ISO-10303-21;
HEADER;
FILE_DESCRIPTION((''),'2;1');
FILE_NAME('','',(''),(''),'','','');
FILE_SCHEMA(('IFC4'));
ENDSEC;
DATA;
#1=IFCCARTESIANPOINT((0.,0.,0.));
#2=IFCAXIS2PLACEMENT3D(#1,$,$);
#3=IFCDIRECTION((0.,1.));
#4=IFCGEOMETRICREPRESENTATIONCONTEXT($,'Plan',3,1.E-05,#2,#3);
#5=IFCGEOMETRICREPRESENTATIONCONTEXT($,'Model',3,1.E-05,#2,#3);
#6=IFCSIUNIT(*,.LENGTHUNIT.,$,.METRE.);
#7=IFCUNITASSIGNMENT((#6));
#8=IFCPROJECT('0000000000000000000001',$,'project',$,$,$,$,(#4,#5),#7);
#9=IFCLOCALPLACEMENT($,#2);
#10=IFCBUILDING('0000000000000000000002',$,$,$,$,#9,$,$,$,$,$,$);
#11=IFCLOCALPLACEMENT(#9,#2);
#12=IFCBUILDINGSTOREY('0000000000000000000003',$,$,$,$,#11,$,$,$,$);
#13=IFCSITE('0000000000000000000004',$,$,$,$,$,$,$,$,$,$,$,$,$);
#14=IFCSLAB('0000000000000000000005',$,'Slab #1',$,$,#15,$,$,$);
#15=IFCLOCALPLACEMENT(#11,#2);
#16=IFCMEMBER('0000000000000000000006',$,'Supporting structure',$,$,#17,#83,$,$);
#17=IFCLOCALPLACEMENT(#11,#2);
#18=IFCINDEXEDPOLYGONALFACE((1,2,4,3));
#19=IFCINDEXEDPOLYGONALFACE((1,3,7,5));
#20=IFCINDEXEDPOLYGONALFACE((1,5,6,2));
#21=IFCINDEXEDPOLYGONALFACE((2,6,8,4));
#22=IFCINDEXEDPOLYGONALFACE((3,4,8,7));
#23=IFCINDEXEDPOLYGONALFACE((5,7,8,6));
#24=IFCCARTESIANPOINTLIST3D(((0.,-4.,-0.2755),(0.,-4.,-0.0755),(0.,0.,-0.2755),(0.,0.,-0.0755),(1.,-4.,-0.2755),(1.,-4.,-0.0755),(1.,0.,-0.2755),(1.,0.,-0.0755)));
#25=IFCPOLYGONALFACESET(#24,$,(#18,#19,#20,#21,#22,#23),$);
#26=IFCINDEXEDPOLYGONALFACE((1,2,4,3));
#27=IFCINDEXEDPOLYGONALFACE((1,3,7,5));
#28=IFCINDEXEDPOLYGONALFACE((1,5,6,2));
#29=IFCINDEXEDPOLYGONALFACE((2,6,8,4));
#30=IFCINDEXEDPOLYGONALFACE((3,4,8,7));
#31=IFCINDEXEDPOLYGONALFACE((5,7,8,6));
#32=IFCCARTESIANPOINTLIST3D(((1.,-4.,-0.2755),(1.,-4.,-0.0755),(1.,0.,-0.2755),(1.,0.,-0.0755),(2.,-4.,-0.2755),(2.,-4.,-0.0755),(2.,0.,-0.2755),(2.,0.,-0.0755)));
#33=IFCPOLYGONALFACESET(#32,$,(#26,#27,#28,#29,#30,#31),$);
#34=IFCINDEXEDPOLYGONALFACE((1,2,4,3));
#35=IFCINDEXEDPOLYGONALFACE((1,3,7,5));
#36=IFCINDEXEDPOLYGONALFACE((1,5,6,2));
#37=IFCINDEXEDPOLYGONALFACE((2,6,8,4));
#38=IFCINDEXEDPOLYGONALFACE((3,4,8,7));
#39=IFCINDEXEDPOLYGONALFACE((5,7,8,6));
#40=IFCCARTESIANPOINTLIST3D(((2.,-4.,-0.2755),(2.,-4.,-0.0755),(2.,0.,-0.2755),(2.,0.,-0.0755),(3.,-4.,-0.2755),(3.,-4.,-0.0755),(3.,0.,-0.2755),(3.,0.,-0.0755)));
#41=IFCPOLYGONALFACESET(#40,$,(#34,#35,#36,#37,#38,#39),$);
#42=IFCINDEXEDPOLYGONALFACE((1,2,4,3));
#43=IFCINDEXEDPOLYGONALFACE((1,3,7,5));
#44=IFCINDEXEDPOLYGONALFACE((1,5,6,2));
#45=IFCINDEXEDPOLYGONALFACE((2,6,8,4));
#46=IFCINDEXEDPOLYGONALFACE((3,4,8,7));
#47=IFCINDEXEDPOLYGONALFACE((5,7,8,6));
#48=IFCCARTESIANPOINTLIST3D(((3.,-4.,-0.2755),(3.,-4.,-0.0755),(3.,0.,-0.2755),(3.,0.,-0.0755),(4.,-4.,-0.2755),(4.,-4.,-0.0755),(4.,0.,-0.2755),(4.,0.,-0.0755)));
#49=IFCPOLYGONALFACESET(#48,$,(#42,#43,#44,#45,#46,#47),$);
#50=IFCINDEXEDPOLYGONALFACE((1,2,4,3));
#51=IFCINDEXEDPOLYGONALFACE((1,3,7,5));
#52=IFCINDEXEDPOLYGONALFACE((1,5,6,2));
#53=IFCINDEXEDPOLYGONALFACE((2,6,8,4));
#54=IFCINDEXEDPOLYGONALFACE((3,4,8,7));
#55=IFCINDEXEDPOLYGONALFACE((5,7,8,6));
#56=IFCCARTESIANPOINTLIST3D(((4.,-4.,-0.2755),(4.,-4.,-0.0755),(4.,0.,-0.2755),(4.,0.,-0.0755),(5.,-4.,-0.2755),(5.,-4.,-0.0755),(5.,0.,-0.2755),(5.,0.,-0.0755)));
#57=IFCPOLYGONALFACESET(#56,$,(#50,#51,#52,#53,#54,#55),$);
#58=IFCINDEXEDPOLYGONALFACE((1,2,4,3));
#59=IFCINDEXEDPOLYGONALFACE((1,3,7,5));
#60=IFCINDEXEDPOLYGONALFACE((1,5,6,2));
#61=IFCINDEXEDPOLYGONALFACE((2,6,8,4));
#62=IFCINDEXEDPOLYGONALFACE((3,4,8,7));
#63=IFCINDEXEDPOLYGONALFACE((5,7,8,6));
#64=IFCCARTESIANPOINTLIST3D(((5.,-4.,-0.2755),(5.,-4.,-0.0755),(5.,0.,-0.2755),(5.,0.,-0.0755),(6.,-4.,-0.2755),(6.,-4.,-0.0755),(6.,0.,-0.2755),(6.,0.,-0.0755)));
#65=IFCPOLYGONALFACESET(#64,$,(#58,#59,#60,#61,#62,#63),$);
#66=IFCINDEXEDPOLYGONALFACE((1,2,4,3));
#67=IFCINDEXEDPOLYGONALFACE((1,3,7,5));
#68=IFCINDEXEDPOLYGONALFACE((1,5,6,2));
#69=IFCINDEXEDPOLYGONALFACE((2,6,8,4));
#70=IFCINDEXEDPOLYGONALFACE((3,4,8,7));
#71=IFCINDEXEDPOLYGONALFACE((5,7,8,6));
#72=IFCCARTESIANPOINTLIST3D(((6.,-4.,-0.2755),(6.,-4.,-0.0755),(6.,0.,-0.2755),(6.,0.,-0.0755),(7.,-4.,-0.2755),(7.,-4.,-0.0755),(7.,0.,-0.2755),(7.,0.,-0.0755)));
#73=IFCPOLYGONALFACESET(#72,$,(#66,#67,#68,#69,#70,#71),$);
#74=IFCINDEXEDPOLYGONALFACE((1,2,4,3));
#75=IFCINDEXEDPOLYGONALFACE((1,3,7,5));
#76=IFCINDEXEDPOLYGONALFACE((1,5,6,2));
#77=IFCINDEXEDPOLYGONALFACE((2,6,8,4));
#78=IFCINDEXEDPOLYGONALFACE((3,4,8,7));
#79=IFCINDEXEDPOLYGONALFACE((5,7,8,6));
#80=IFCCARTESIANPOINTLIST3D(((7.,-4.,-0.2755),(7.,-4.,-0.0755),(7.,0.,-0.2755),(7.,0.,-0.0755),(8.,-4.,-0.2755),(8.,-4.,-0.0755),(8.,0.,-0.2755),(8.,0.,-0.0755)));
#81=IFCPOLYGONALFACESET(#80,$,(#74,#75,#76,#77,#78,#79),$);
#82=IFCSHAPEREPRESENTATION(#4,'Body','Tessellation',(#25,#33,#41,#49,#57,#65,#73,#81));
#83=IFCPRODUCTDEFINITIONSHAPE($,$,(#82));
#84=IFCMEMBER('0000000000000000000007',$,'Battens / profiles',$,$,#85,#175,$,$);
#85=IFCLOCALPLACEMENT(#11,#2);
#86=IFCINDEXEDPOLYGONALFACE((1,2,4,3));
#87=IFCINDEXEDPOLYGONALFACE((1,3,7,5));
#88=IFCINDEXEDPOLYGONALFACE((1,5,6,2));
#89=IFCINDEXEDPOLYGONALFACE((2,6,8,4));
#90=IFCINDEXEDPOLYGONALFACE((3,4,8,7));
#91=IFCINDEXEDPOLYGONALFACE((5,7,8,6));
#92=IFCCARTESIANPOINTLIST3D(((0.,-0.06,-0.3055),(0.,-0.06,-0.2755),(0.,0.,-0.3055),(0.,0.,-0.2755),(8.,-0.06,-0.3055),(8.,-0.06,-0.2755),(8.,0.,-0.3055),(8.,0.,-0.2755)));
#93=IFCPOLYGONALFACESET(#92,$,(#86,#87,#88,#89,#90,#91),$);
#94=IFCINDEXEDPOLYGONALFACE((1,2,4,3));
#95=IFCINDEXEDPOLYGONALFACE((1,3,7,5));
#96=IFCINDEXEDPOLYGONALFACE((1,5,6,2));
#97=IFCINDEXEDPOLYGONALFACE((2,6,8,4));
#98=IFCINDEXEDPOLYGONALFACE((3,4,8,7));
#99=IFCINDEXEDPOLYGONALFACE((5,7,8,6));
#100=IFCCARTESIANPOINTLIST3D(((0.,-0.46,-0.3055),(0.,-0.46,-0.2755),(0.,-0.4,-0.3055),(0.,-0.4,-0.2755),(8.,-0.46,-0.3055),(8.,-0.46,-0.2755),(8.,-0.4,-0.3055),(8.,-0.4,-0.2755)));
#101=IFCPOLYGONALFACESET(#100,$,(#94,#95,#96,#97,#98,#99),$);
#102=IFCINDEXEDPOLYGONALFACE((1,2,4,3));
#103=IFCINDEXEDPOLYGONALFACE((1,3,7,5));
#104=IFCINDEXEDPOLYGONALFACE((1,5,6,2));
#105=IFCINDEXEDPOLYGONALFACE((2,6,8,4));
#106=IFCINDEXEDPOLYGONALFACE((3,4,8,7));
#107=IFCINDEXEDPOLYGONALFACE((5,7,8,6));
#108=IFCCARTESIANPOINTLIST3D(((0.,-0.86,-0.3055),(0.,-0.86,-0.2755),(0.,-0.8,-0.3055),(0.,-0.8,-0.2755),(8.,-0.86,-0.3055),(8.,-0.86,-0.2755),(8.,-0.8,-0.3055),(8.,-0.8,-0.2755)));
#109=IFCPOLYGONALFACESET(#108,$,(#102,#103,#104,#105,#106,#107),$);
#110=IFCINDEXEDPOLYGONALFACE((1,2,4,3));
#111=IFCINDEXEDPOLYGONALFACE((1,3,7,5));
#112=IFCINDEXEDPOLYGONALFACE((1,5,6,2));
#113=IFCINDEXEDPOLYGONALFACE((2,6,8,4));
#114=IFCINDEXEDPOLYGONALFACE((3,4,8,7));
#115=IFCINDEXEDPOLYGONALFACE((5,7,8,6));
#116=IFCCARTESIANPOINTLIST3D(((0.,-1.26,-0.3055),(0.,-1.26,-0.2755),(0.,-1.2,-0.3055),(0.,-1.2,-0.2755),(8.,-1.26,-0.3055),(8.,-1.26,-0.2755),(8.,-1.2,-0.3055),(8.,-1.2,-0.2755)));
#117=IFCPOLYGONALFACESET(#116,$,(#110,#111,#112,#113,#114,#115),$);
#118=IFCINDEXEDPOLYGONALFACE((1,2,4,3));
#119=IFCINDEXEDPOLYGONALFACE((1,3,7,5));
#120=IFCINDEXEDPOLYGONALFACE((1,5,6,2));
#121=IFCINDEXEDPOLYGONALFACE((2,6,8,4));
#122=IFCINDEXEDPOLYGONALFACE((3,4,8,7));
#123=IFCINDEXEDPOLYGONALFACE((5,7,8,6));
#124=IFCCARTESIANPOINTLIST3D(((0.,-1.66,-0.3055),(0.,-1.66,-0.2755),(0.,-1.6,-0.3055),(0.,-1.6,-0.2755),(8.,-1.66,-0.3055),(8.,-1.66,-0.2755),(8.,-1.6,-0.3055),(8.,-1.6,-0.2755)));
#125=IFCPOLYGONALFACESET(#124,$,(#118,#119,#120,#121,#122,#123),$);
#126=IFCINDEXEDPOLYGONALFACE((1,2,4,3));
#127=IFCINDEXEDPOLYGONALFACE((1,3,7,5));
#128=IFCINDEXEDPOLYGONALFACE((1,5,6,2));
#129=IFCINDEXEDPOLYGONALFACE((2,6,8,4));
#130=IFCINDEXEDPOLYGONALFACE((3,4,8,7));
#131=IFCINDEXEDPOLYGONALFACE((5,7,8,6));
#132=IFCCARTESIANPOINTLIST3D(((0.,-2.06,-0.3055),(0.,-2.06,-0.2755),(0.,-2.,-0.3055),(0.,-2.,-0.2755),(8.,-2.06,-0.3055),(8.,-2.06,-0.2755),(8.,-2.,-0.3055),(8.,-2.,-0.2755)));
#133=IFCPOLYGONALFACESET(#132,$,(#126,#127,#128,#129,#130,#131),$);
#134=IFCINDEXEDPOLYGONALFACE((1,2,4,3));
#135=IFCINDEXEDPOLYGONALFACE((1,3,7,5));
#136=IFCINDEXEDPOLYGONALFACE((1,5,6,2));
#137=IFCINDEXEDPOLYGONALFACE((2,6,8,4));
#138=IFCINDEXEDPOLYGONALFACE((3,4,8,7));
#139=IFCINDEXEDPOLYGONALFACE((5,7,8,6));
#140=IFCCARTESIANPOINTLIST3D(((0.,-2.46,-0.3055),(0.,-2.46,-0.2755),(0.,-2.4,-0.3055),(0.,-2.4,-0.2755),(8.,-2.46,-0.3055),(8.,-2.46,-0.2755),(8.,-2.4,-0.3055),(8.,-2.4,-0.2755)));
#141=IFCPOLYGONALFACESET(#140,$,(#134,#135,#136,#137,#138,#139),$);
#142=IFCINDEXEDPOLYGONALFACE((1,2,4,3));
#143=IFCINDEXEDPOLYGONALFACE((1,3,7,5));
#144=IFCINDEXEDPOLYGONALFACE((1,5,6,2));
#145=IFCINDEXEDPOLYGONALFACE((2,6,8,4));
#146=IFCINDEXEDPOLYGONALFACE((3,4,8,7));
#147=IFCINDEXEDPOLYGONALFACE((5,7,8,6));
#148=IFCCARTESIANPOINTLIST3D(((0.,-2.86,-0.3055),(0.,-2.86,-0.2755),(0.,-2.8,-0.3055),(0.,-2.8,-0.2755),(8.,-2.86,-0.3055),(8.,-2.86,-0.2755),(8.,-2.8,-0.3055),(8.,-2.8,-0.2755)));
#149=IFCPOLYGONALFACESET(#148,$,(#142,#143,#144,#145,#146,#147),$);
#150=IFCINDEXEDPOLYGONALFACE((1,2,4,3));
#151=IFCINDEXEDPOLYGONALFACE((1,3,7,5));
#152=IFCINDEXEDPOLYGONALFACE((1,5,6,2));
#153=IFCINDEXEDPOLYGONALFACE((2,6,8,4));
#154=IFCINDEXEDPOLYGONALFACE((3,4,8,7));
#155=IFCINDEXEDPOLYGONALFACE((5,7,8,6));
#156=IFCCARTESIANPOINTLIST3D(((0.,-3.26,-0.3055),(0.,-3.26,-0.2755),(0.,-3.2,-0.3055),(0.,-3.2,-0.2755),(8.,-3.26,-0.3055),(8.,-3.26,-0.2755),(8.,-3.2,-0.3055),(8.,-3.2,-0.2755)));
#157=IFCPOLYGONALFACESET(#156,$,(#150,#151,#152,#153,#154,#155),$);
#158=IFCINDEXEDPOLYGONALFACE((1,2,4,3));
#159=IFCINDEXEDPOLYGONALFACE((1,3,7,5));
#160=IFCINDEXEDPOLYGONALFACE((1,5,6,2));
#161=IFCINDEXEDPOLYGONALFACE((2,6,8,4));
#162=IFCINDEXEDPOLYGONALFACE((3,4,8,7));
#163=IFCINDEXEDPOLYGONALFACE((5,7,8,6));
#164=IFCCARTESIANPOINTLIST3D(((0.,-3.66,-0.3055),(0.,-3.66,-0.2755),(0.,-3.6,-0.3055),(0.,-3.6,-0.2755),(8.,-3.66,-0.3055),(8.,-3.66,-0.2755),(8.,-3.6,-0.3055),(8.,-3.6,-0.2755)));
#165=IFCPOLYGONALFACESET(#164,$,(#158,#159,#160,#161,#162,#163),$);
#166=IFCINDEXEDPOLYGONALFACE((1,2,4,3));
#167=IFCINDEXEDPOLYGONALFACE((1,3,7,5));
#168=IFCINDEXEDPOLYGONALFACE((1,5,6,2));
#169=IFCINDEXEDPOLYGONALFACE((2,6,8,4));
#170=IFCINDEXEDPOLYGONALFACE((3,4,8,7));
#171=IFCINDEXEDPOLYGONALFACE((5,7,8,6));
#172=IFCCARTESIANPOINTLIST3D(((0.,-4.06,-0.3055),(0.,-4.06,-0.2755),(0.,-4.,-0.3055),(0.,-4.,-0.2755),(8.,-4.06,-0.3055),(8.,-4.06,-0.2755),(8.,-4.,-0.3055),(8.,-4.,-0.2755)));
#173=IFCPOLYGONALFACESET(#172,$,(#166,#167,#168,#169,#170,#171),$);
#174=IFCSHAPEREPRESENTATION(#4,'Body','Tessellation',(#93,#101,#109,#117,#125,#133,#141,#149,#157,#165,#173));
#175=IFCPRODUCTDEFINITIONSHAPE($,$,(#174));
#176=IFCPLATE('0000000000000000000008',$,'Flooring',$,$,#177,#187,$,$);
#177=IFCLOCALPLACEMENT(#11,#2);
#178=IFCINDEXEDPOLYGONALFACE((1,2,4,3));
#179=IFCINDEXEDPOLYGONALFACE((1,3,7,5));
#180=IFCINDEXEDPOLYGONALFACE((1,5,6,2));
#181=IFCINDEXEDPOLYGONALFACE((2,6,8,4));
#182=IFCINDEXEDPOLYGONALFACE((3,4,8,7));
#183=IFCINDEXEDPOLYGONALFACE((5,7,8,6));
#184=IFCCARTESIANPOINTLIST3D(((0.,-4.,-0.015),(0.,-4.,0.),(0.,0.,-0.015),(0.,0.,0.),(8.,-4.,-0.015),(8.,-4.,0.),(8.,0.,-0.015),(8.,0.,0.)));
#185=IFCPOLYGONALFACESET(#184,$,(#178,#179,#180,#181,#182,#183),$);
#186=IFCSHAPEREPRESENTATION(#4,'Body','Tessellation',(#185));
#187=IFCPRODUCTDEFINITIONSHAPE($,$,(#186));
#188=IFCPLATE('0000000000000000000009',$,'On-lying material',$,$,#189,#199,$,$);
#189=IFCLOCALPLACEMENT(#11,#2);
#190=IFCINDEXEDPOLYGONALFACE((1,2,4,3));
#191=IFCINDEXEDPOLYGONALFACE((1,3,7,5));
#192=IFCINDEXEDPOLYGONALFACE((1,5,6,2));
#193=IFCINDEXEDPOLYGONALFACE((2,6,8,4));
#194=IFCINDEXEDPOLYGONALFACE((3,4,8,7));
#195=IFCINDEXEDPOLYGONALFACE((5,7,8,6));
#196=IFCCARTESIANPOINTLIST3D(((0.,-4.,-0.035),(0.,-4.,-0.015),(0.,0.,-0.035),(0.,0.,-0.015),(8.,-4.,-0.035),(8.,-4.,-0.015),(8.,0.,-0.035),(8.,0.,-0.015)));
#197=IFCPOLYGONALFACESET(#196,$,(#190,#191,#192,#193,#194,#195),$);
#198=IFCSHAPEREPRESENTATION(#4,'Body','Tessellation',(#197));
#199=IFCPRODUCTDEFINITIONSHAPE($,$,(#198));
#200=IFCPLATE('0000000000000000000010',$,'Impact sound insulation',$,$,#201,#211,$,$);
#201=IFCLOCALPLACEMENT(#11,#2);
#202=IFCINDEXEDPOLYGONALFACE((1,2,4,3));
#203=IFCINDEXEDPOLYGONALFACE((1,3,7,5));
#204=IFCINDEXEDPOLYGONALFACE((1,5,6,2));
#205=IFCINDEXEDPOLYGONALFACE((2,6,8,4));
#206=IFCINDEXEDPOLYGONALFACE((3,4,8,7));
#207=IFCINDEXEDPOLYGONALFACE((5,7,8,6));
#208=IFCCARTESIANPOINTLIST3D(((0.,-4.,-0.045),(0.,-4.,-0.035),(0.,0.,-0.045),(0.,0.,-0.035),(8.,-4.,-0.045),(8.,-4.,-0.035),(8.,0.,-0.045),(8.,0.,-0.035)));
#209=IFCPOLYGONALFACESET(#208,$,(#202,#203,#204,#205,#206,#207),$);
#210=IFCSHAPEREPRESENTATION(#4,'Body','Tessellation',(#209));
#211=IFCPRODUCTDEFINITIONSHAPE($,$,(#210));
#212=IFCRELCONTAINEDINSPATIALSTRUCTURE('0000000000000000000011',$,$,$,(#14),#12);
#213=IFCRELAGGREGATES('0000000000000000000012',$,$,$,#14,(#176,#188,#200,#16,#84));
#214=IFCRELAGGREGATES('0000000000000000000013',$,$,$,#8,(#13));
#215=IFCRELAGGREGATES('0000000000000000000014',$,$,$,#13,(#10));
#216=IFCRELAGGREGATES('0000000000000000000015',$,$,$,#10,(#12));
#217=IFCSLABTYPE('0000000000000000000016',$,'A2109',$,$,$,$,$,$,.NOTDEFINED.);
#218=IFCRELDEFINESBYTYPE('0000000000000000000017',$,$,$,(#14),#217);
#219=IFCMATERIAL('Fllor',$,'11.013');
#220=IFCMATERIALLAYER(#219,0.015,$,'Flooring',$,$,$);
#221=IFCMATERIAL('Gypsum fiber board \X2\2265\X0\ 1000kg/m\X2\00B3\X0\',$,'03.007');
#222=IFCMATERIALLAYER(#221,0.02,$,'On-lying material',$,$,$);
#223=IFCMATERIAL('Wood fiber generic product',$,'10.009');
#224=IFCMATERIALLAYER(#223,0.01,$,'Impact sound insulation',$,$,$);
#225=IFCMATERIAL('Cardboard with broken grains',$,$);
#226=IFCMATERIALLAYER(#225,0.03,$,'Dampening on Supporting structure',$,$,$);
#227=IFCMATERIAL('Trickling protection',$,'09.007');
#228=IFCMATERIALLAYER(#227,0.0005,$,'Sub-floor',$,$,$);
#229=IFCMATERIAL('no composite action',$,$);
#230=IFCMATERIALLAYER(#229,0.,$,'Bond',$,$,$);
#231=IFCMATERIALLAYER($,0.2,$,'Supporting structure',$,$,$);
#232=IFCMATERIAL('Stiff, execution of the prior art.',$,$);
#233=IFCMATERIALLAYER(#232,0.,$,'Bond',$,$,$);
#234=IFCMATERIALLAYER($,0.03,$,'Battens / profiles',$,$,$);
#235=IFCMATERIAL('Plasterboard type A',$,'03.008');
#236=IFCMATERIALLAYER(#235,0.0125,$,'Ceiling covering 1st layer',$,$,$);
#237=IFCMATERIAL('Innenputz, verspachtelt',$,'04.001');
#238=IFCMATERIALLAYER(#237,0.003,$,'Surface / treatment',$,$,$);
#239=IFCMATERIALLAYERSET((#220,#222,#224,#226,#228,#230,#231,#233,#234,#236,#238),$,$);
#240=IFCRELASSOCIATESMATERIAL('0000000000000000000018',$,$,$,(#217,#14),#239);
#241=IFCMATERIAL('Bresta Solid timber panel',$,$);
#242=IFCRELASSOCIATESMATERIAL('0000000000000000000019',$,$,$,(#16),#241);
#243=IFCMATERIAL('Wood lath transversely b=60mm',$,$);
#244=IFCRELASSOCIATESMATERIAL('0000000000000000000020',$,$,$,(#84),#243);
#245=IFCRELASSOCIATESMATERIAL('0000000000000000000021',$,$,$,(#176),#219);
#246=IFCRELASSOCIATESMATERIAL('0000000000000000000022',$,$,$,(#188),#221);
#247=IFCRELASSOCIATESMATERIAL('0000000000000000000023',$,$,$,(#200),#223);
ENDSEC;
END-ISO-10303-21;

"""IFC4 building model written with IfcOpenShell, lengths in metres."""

from ifc_helpers import new_model, si_unit, direction, frame, frame_2d, origin, origin_with_axes, place, context, project, spatial, rectangle, extrude, material, layer, layer_set, type_object, element, aggregate, save


model = new_model("IFC4")

# Units and contexts
plan_context = context("Plan", 3, precision=1e-05, world=origin(), true_north=direction((0.0, 1.0)))
model_context = context("Model", 3, precision=1e-05, world=origin(), true_north=direction((0.0, 1.0)))
ifc_project = project(units=[si_unit("LENGTHUNIT", "METRE")], contexts=[plan_context, model_context])

# Site, building, storey
site = spatial("IfcSite", under=ifc_project)
building_placement = place(None, origin())
building = spatial("IfcBuilding", under=site, at=building_placement)
storey_placement = place(building_placement, origin())
storey = spatial("IfcBuildingStorey", under=building, at=storey_placement)

# Slab, members, plates
ifc_material_1 = material(Name="Fllor", Category="11.013")
ifc_layer_1 = layer(ifc_material_1, 0.015, Name="Flooring")
ifc_material_2 = material(Name="Gypsum fiber board ≥ 1000kg/m³", Category="03.007")
ifc_layer_2 = layer(ifc_material_2, 0.02, Name="On-lying material")
ifc_material_3 = material(Name="Wood fiber generic product", Category="10.009")
ifc_layer_3 = layer(ifc_material_3, 0.01, Name="Impact sound insulation")
ifc_material_4 = material(Name="Cardboard with broken grains")
ifc_layer_4 = layer(ifc_material_4, 0.03, Name="Dampening on Supporting structure")
ifc_material_5 = material(Name="Trickling protection", Category="09.007")
ifc_layer_5 = layer(ifc_material_5, 0.0005, Name="Sub-floor")
ifc_material_6 = material(Name="no composite action")
ifc_layer_6 = layer(ifc_material_6, 0.0, Name="Bond")
ifc_layer_7 = layer(None, 0.2, Name="Supporting structure")
ifc_material_7 = material(Name="Stiff, execution of the prior art.")
ifc_layer_8 = layer(ifc_material_7, 0.0, Name="Bond")
ifc_layer_9 = layer(None, 0.03, Name="Battens / profiles")
ifc_material_8 = material(Name="Plasterboard type A", Category="03.008")
ifc_layer_10 = layer(ifc_material_8, 0.0125, Name="Ceiling covering 1st layer")
ifc_material_9 = material(Name="Innenputz, verspachtelt", Category="04.001")
ifc_layer_11 = layer(ifc_material_9, 0.003, Name="Surface / treatment")
ifc_layer_set = layer_set([ifc_layer_1, ifc_layer_2, ifc_layer_3, ifc_layer_4, ifc_layer_5, ifc_layer_6, ifc_layer_7, ifc_layer_8, ifc_layer_9, ifc_layer_10, ifc_layer_11])
slab_type = type_object("IfcSlabType", Name="A2109", PredefinedType="NOTDEFINED", material=ifc_layer_set)
slab_placement = place(None, frame((0.0, 0.0, 0.0), z_axis=(0.0, 0.0, -1.0), x_axis=(1.0, 0.0, 0.0)))
slab = element("IfcSlab", 1, at=slab_placement, inside=storey, type_object=slab_type, material=ifc_layer_set, Name="Slab #1")
ifc_material_10 = material(Name="Bresta Solid timber panel")
member_1_placement = place(slab_placement, origin())
member_1 = element("IfcMember", 2, at=member_1_placement, material=ifc_material_10, Name="Supporting structure", context=plan_context, shape_type="SweptSolid", body=[
    extrude(rectangle(XDim=1.0, YDim=0.2, at=frame_2d((0.5, 0.1), x_axis=(1.0, 0.0))), frame((0.0, 4.0, 0.0755), z_axis=(0.0, -1.0, 0.0), x_axis=(1.0, 0.0, 0.0)), (0.0, 0.0, 1.0), 4.0),
    extrude(rectangle(XDim=1.0, YDim=0.2, at=frame_2d((0.5, 0.1), x_axis=(1.0, 0.0))), frame((1.0, 4.0, 0.0755), z_axis=(0.0, -1.0, 0.0), x_axis=(1.0, 0.0, 0.0)), (0.0, 0.0, 1.0), 4.0),
    extrude(rectangle(XDim=1.0, YDim=0.2, at=frame_2d((0.5, 0.1), x_axis=(1.0, 0.0))), frame((2.0, 4.0, 0.0755), z_axis=(0.0, -1.0, 0.0), x_axis=(1.0, 0.0, 0.0)), (0.0, 0.0, 1.0), 4.0),
    extrude(rectangle(XDim=1.0, YDim=0.2, at=frame_2d((0.5, 0.1), x_axis=(1.0, 0.0))), frame((3.0, 4.0, 0.0755), z_axis=(0.0, -1.0, 0.0), x_axis=(1.0, 0.0, 0.0)), (0.0, 0.0, 1.0), 4.0),
    extrude(rectangle(XDim=1.0, YDim=0.2, at=frame_2d((0.5, 0.1), x_axis=(1.0, 0.0))), frame((4.0, 4.0, 0.0755), z_axis=(0.0, -1.0, 0.0), x_axis=(1.0, 0.0, 0.0)), (0.0, 0.0, 1.0), 4.0),
    extrude(rectangle(XDim=1.0, YDim=0.2, at=frame_2d((0.5, 0.1), x_axis=(1.0, 0.0))), frame((5.0, 4.0, 0.0755), z_axis=(0.0, -1.0, 0.0), x_axis=(1.0, 0.0, 0.0)), (0.0, 0.0, 1.0), 4.0),
    extrude(rectangle(XDim=1.0, YDim=0.2, at=frame_2d((0.5, 0.1), x_axis=(1.0, 0.0))), frame((6.0, 4.0, 0.0755), z_axis=(0.0, -1.0, 0.0), x_axis=(1.0, 0.0, 0.0)), (0.0, 0.0, 1.0), 4.0),
    extrude(rectangle(XDim=1.0, YDim=0.2, at=frame_2d((0.5, 0.1), x_axis=(1.0, 0.0))), frame((7.0, 4.0, 0.0755), z_axis=(0.0, -1.0, 0.0), x_axis=(1.0, 0.0, 0.0)), (0.0, 0.0, 1.0), 4.0),
])
ifc_material_11 = material(Name="Wood lath transversely b=60mm")
member_2_placement = place(slab_placement, origin())
member_2 = element("IfcMember", 3, at=member_2_placement, material=ifc_material_11, Name="Battens / profiles", context=plan_context, shape_type="SweptSolid", body=[
    extrude(rectangle(XDim=0.06, YDim=0.03, at=frame_2d((0.03, 0.015), x_axis=(1.0, 0.0))), frame((0.0, 0.0, 0.2755), z_axis=(1.0, 0.0, 0.0), x_axis=(0.0, 1.0, 0.0)), (0.0, 0.0, 1.0), 8.0),
    extrude(rectangle(XDim=0.06, YDim=0.03, at=frame_2d((0.03, 0.015), x_axis=(1.0, 0.0))), frame((0.0, 0.4, 0.2755), z_axis=(1.0, 0.0, 0.0), x_axis=(0.0, 1.0, 0.0)), (0.0, 0.0, 1.0), 8.0),
    extrude(rectangle(XDim=0.06, YDim=0.03, at=frame_2d((0.03, 0.015), x_axis=(1.0, 0.0))), frame((0.0, 0.8, 0.2755), z_axis=(1.0, 0.0, 0.0), x_axis=(0.0, 1.0, 0.0)), (0.0, 0.0, 1.0), 8.0),
    extrude(rectangle(XDim=0.06, YDim=0.03, at=frame_2d((0.03, 0.015), x_axis=(1.0, 0.0))), frame((0.0, 1.2, 0.2755), z_axis=(1.0, 0.0, 0.0), x_axis=(0.0, 1.0, 0.0)), (0.0, 0.0, 1.0), 8.0),
    extrude(rectangle(XDim=0.06, YDim=0.03, at=frame_2d((0.03, 0.015), x_axis=(1.0, 0.0))), frame((0.0, 1.6, 0.2755), z_axis=(1.0, 0.0, 0.0), x_axis=(0.0, 1.0, 0.0)), (0.0, 0.0, 1.0), 8.0),
    extrude(rectangle(XDim=0.06, YDim=0.03, at=frame_2d((0.03, 0.015), x_axis=(1.0, 0.0))), frame((0.0, 2.0, 0.2755), z_axis=(1.0, 0.0, 0.0), x_axis=(0.0, 1.0, 0.0)), (0.0, 0.0, 1.0), 8.0),
    extrude(rectangle(XDim=0.06, YDim=0.03, at=frame_2d((0.03, 0.015), x_axis=(1.0, 0.0))), frame((0.0, 2.4, 0.2755), z_axis=(1.0, 0.0, 0.0), x_axis=(0.0, 1.0, 0.0)), (0.0, 0.0, 1.0), 8.0),
    extrude(rectangle(XDim=0.06, YDim=0.03, at=frame_2d((0.03, 0.015), x_axis=(1.0, 0.0))), frame((0.0, 2.8, 0.2755), z_axis=(1.0, 0.0, 0.0), x_axis=(0.0, 1.0, 0.0)), (0.0, 0.0, 1.0), 8.0),
    extrude(rectangle(XDim=0.06, YDim=0.03, at=frame_2d((0.03, 0.015), x_axis=(1.0, 0.0))), frame((0.0, 3.2, 0.2755), z_axis=(1.0, 0.0, 0.0), x_axis=(0.0, 1.0, 0.0)), (0.0, 0.0, 1.0), 8.0),
    extrude(rectangle(XDim=0.06, YDim=0.03, at=frame_2d((0.03, 0.015), x_axis=(1.0, 0.0))), frame((0.0, 3.6, 0.2755), z_axis=(1.0, 0.0, 0.0), x_axis=(0.0, 1.0, 0.0)), (0.0, 0.0, 1.0), 8.0),
    extrude(rectangle(XDim=0.06, YDim=0.03, at=frame_2d((0.03, 0.015), x_axis=(1.0, 0.0))), frame((0.0, 4.0, 0.2755), z_axis=(1.0, 0.0, 0.0), x_axis=(0.0, 1.0, 0.0)), (0.0, 0.0, 1.0), 8.0),
])
plate_1_placement = place(slab_placement, origin())
plate_1 = element("IfcPlate", 4, at=plate_1_placement, material=ifc_material_1, Name="Flooring", context=plan_context, shape_type="SweptSolid", body=[
    extrude(rectangle(XDim=8.0, YDim=4.0, at=frame_2d((4.0, 2.0), x_axis=(1.0, 0.0))), origin_with_axes(), (0.0, 0.0, 1.0), 0.015),
])
plate_2_placement = place(slab_placement, origin())
plate_2 = element("IfcPlate", 5, at=plate_2_placement, material=ifc_material_2, Name="On-lying material", context=plan_context, shape_type="SweptSolid", body=[
    extrude(rectangle(XDim=8.0, YDim=4.0, at=frame_2d((4.0, 2.0), x_axis=(1.0, 0.0))), frame((0.0, 0.0, 0.015), z_axis=(0.0, 0.0, 1.0), x_axis=(1.0, 0.0, 0.0)), (0.0, 0.0, 1.0), 0.02),
])
plate_3_placement = place(slab_placement, origin())
plate_3 = element("IfcPlate", 6, at=plate_3_placement, material=ifc_material_3, Name="Impact sound insulation", context=plan_context, shape_type="SweptSolid", body=[
    extrude(rectangle(XDim=8.0, YDim=4.0, at=frame_2d((4.0, 2.0), x_axis=(1.0, 0.0))), frame((0.0, 0.0, 0.035), z_axis=(0.0, 0.0, 1.0), x_axis=(1.0, 0.0, 0.0)), (0.0, 0.0, 1.0), 0.01),
])
aggregate(slab, [plate_1, plate_2, plate_3, member_1, member_2])

save(model, "model.ifc")
